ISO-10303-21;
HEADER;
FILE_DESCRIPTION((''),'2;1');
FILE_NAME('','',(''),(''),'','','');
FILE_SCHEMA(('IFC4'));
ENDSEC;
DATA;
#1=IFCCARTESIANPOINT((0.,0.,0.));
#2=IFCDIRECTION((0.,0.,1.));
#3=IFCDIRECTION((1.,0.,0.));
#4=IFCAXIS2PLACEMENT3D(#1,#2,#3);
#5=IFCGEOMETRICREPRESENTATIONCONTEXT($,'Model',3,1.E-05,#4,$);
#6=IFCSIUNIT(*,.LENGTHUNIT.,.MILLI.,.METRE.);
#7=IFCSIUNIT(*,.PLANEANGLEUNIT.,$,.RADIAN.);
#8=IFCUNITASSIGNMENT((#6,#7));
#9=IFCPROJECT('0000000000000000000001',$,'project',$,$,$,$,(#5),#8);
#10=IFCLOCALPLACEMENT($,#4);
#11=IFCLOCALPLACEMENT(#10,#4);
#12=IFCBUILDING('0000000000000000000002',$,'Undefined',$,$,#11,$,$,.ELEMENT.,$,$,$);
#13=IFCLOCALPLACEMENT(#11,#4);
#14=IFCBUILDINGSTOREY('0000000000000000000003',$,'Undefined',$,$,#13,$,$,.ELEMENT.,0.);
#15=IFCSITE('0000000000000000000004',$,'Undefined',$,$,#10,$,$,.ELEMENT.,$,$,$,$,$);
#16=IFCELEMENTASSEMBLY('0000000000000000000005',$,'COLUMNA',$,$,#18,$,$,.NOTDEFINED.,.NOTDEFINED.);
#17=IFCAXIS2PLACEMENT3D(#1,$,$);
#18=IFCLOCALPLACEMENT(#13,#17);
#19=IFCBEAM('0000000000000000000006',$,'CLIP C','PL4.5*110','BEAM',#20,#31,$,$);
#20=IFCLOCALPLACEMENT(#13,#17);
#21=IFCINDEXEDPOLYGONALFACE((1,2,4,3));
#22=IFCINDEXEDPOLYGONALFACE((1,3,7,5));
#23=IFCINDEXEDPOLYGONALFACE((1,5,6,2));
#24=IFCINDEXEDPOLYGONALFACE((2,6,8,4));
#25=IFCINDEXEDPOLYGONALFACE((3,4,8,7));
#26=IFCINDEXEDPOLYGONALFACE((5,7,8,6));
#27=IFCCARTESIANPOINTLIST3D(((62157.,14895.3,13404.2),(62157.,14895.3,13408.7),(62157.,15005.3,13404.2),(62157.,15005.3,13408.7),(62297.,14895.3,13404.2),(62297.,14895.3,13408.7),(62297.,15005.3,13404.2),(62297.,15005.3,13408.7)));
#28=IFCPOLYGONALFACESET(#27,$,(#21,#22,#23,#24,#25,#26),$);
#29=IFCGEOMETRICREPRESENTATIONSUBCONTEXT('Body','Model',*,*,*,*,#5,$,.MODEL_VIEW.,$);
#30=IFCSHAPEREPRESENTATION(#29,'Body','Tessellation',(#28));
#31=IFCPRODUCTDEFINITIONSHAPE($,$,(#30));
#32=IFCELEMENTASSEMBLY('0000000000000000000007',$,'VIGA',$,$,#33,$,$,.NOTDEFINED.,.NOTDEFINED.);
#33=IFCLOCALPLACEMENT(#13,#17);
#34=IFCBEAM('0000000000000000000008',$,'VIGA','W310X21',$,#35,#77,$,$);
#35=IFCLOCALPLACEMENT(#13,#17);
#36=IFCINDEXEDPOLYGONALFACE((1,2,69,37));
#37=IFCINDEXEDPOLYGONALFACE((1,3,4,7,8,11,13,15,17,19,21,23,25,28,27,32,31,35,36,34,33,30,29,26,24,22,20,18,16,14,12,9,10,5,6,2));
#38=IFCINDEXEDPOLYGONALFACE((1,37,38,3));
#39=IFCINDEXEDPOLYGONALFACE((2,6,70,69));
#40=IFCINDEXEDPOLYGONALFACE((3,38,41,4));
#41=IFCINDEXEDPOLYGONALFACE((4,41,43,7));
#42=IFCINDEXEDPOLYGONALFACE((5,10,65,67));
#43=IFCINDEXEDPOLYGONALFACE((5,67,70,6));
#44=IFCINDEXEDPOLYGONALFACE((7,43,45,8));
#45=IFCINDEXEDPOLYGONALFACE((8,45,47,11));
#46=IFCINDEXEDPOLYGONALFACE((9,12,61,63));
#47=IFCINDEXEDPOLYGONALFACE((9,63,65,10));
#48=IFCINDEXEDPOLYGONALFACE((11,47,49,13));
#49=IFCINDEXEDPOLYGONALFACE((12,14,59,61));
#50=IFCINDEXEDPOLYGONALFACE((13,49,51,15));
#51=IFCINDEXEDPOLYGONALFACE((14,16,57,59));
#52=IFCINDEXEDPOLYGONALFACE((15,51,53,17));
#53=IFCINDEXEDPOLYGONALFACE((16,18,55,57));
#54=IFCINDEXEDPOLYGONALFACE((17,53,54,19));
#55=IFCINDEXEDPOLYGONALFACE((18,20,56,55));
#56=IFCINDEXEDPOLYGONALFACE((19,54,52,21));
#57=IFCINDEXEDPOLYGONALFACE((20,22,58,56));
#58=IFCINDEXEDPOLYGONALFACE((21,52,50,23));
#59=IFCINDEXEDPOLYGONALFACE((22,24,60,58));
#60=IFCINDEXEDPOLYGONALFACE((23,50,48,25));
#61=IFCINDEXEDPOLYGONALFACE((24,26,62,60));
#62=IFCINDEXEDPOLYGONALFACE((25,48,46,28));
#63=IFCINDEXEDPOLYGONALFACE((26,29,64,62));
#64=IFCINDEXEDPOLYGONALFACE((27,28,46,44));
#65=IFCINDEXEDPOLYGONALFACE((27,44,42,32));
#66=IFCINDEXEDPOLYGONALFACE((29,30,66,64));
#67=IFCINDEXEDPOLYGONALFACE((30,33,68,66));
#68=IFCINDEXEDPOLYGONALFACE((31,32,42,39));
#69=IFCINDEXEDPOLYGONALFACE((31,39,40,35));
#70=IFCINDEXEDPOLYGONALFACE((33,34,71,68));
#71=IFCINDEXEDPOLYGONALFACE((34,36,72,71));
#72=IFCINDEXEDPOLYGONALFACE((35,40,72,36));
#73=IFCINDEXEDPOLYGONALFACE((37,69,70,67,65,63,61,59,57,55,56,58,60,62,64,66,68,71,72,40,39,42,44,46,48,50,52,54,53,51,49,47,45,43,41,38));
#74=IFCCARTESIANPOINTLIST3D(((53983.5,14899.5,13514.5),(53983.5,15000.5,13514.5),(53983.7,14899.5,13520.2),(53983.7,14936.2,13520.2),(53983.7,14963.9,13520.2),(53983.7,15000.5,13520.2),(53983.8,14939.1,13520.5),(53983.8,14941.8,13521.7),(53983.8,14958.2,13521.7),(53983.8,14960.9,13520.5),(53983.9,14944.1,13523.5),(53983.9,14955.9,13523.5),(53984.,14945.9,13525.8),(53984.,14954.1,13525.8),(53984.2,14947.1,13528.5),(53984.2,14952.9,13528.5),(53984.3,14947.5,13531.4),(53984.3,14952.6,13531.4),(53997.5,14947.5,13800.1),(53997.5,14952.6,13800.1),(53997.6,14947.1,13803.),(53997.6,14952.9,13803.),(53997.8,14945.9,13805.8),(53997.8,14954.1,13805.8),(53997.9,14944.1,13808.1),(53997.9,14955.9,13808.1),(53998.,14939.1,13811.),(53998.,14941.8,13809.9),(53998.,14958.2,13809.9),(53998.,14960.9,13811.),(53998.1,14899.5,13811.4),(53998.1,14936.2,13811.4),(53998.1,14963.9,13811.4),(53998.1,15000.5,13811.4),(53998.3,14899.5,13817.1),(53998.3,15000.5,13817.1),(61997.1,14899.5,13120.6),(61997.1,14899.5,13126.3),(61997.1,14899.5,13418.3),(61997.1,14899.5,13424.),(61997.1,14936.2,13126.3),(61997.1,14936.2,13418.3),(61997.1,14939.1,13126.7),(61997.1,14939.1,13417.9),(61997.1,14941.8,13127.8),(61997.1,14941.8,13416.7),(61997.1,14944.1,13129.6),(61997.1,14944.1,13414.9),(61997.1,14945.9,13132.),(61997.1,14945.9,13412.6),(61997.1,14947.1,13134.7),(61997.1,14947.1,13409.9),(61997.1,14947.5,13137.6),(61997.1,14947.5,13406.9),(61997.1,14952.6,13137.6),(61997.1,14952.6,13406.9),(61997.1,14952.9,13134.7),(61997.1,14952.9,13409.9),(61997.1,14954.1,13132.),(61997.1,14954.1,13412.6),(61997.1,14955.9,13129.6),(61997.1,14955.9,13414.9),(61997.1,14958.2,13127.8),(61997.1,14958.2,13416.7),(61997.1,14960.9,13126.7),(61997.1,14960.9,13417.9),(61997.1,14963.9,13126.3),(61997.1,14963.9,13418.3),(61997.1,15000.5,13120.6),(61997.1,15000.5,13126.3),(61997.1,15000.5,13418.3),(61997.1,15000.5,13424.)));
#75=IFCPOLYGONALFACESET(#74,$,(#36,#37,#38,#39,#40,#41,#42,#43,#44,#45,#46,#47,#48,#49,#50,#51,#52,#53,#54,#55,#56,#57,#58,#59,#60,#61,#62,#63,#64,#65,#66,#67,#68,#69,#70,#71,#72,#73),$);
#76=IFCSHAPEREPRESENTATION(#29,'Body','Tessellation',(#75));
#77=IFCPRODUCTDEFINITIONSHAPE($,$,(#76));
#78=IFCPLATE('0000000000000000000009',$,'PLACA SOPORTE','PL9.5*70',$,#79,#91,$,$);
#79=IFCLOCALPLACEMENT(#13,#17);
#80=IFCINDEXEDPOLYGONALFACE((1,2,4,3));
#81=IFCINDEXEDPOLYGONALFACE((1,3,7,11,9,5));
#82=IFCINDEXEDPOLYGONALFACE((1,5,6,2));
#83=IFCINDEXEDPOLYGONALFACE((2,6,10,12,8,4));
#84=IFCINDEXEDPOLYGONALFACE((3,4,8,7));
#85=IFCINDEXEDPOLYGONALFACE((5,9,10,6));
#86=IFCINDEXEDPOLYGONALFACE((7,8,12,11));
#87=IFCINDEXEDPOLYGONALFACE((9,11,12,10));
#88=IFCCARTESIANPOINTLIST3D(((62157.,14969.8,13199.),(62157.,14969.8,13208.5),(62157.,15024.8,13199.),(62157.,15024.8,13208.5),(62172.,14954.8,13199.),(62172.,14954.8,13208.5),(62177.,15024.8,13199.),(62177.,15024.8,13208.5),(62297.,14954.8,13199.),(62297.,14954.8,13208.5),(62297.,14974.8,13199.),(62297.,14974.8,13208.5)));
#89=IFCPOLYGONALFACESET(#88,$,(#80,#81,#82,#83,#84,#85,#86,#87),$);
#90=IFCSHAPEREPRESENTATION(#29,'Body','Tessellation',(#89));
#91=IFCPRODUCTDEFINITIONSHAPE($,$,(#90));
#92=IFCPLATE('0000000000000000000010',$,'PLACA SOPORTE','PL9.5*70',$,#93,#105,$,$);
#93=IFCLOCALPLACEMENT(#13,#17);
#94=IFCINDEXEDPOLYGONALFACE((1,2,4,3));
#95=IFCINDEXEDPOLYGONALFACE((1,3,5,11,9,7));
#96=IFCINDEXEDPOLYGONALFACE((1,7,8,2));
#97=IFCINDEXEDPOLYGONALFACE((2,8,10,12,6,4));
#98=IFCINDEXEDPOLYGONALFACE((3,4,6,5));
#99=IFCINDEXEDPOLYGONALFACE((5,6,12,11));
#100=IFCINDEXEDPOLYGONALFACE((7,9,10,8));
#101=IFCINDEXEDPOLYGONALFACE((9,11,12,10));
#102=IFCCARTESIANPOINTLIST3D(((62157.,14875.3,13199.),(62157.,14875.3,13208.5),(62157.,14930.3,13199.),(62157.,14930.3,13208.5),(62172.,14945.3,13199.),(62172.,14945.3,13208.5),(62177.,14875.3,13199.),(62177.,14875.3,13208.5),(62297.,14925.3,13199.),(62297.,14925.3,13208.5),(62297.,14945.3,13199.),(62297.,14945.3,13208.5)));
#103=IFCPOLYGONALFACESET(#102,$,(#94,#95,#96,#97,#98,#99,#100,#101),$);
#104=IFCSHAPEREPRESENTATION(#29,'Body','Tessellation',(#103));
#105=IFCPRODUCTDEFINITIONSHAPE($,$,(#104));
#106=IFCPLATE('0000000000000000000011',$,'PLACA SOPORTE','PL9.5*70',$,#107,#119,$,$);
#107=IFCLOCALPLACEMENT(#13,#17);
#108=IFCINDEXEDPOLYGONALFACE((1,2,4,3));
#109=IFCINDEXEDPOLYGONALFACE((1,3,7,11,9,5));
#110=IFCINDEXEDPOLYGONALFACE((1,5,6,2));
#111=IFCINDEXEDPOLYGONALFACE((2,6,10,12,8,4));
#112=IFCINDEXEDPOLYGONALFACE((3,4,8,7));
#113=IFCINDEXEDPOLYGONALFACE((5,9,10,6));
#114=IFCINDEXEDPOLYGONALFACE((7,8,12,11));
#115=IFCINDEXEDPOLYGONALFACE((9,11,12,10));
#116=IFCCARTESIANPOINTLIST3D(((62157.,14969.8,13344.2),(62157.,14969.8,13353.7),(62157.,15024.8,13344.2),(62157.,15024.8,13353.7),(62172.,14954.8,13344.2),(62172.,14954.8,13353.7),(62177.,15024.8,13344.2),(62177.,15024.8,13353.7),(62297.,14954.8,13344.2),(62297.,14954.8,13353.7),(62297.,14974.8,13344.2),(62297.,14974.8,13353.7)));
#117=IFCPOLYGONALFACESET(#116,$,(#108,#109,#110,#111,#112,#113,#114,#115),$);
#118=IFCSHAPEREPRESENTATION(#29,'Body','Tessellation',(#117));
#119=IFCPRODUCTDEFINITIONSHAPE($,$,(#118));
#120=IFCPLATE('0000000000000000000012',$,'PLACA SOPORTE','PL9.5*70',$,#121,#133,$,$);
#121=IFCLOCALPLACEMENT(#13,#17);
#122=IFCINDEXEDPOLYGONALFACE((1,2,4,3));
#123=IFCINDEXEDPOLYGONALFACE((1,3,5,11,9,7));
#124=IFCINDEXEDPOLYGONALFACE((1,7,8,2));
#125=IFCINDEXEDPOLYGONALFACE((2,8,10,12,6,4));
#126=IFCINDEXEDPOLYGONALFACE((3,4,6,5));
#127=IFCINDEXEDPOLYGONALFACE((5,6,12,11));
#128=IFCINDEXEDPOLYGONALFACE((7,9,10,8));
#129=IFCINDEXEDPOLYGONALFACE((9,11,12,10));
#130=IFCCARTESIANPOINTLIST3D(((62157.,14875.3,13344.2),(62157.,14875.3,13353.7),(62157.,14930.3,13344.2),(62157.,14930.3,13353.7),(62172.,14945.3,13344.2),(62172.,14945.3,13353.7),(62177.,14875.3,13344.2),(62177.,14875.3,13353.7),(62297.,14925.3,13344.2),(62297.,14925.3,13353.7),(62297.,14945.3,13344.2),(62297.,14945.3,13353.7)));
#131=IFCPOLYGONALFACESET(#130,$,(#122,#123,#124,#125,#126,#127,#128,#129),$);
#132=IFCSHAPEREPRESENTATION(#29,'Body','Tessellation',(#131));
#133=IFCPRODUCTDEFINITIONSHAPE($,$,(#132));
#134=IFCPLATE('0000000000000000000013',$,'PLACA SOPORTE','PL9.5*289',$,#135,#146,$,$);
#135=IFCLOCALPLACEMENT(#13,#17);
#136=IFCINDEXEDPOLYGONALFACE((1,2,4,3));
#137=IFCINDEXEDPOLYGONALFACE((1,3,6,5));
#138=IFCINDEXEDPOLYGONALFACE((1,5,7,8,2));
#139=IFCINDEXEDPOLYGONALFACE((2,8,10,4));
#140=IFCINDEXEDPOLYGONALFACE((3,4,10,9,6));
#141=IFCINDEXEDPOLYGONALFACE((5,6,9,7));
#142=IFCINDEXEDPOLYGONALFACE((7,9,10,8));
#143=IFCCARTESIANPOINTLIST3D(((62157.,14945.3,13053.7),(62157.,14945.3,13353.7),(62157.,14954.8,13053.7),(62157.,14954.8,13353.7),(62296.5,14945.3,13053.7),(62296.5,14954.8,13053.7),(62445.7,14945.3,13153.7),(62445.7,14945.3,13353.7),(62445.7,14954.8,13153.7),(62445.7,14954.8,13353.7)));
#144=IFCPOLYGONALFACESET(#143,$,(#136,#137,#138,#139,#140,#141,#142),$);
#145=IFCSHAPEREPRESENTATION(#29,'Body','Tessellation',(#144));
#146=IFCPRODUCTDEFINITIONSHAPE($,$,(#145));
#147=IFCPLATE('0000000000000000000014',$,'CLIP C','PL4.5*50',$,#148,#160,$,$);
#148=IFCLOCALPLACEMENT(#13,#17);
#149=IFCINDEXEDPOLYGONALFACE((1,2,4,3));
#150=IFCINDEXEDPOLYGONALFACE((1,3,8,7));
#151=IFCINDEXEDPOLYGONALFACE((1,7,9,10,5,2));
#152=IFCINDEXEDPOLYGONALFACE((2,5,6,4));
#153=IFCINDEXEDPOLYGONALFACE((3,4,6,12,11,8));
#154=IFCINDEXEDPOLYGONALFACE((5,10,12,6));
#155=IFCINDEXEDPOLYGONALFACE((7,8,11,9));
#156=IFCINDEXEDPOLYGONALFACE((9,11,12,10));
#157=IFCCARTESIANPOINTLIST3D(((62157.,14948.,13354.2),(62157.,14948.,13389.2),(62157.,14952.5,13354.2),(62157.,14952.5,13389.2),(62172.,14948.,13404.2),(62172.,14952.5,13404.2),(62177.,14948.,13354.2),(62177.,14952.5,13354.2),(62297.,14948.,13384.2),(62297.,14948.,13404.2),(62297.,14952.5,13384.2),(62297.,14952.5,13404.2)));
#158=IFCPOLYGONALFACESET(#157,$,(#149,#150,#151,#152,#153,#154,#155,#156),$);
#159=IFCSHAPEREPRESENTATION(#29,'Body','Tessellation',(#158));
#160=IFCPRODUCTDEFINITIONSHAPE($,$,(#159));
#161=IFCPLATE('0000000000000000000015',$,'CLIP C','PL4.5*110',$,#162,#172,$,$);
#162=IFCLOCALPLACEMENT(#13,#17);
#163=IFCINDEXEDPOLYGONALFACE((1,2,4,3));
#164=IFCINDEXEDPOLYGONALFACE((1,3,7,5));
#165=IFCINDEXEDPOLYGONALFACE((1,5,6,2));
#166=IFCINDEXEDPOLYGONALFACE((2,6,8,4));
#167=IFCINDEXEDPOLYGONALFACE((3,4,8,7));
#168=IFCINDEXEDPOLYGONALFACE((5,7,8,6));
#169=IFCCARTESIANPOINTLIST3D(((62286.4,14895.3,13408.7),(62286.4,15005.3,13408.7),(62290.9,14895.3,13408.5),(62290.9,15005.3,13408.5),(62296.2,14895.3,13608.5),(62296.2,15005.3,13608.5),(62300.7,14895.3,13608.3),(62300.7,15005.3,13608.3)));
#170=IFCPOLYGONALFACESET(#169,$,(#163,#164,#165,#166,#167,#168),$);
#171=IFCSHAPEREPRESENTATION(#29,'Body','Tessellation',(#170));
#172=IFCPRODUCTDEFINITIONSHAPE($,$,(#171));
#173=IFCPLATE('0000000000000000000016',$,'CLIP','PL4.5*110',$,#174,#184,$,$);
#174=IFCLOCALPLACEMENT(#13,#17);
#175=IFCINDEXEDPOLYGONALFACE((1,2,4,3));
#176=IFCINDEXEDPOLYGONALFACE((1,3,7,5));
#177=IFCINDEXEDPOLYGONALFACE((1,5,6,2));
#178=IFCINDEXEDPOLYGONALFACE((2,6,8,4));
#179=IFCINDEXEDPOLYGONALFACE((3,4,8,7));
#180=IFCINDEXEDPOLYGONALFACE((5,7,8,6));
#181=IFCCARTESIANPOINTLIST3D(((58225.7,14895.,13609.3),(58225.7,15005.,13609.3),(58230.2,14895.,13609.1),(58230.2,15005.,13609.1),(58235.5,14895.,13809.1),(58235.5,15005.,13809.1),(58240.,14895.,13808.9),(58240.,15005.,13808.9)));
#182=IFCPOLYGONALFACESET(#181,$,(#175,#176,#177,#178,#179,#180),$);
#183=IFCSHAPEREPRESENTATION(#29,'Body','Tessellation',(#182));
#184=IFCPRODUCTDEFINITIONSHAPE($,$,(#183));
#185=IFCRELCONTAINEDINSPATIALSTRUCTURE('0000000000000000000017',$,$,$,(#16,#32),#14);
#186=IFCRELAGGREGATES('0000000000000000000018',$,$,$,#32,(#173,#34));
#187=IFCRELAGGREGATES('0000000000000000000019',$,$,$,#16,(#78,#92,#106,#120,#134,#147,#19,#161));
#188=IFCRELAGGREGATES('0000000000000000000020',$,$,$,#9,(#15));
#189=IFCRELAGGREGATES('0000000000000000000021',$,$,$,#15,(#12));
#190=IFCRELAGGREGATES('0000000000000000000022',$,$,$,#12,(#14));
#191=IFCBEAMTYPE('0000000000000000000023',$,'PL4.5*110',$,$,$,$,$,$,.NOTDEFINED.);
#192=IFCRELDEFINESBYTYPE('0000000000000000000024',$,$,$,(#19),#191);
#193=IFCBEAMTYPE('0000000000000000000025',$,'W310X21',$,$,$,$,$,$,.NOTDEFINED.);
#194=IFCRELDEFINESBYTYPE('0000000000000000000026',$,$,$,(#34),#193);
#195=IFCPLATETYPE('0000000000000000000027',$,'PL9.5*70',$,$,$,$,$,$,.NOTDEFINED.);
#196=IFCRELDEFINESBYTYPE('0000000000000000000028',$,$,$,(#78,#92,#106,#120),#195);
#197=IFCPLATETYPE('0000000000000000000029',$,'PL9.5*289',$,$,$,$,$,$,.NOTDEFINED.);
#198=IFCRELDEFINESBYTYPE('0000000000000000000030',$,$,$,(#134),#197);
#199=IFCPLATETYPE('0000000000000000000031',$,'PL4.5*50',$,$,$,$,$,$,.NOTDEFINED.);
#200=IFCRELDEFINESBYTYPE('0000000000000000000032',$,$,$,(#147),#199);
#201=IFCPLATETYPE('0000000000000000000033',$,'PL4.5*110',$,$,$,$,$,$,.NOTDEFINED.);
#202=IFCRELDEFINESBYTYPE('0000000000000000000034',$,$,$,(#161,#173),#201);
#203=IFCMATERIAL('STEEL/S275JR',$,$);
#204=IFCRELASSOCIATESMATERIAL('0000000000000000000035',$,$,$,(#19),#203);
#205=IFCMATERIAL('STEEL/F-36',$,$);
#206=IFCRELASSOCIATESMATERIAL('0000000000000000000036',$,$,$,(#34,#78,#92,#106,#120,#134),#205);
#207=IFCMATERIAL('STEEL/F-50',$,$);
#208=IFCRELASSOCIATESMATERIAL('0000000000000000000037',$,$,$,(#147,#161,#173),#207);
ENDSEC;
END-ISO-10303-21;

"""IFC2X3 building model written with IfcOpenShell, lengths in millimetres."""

from ifc_helpers import new_model, si_unit, frame, origin_with_axes, origin_2d_with_axis, place, context, subcontext, project, spatial, polyline, rectangle, i_section, outline, extrude, clip, halfspace, material, type_object, element, aggregate, save


model = new_model("IFC2X3")

# Units and contexts
model_context = context("Model", 3, precision=1e-05, world=origin_with_axes())
body_context = subcontext(model_context, "Body", "Model", "MODEL_VIEW")
ifc_project = project(units=[si_unit("LENGTHUNIT", "METRE", prefix="MILLI"), si_unit("PLANEANGLEUNIT", "RADIAN")], contexts=[model_context])

# Site, building, storey
site_placement = place(None, origin_with_axes())
site = spatial("IfcSite", under=ifc_project, at=site_placement, Name="Undefined", CompositionType="ELEMENT")
building_placement = place(site_placement, origin_with_axes())
building = spatial("IfcBuilding", under=site, at=building_placement, Name="Undefined", CompositionType="ELEMENT")
storey_placement = place(building_placement, origin_with_axes())
storey = spatial("IfcBuildingStorey", under=building, at=storey_placement, Name="Undefined", CompositionType="ELEMENT", Elevation=0.0)

# Element assemblies, beams
assembly_1_placement = place(storey_placement, origin_with_axes())
assembly_1 = element("IfcElementAssembly", 1, at=assembly_1_placement, inside=storey, Name="COLUMNA", AssemblyPlace="NOTDEFINED", PredefinedType="NOTDEFINED")
ifc_material_1 = material(Name="STEEL/S275JR")
beam_type_1 = type_object("IfcBeamType", Name="PL4.5*110", PredefinedType="NOTDEFINED")
beam_1_placement = place(assembly_1_placement, frame((62297.0, 14950.3, 13406.5), z_axis=(0.0, -1.0, 0.0), x_axis=(-1.0, 0.0, 0.0)))
beam_1 = element("IfcBeam", 2, at=beam_1_placement, type_object=beam_type_1, material=ifc_material_1, Name="CLIP C", Description="PL4.5*110", ObjectType="BEAM", context=body_context, shape_type="SweptSolid", body=[
    extrude(rectangle(XDim=4.5, YDim=110.0, at=origin_2d_with_axis()), frame((140.0, 0.0, 0.0), z_axis=(-1.0, 0.0, 0.0), x_axis=(0.0, -1.0, 0.0)), (0.0, 0.0, 1.0), 140.0),
])
assembly_2_placement = place(storey_placement, origin_with_axes())
assembly_2 = element("IfcElementAssembly", 3, at=assembly_2_placement, inside=storey, Name="VIGA", AssemblyPlace="NOTDEFINED", PredefinedType="NOTDEFINED")
ifc_material_2 = material(Name="STEEL/F-36")
beam_type_2 = type_object("IfcBeamType", Name="W310X21", PredefinedType="NOTDEFINED")
beam_2_placement = place(assembly_2_placement, frame((62081.1, 14950.0, 13268.2), z_axis=(0.04909, 0.0, 0.998794), x_axis=(-0.998794, 0.0, 0.04909)))
beam_2 = element("IfcBeam", 4, at=beam_2_placement, type_object=beam_type_2, material=ifc_material_2, Name="VIGA", Description="W310X21", context=body_context, shape_type="Clipping", body=[
    clip(extrude(i_section(OverallWidth=101.0, OverallDepth=303.0, WebThickness=5.1, FlangeThickness=5.7, FilletRadius=11.3, at=origin_2d_with_axis()), frame((8099.9, 0.0, 0.0), z_axis=(-1.0, 0.0, 0.0), x_axis=(0.0, -1.0, 0.0)), (0.0, 0.0, 1.0), 8099.9), halfspace(frame((91.5, 0.0, 151.5), z_axis=(0.998794, 0.0, -0.049091), x_axis=(0.0, 1.0, 0.0)), True)),
])

# Plates
plate_type_1 = type_object("IfcPlateType", Name="PL9.5*70", PredefinedType="NOTDEFINED")
plate_1_placement = place(assembly_1_placement, frame((62157.0, 14954.8, 13203.7), z_axis=(0.0, 0.0, -1.0), x_axis=(0.00004, 1.0, 0.0)))
plate_1 = element("IfcPlate", 5, at=plate_1_placement, type_object=plate_type_1, material=ifc_material_2, Name="PLACA SOPORTE", Description="PL9.5*70", context=body_context, shape_type="SweptSolid", body=[
    extrude(outline(polyline([(0.0, 15.0), (15.0, 0.0), (70.0, 0.0), (70.0, 20.0), (20.0, 140.0), (0.0, 140.0), (0.0, 15.0)])), frame((0.0, 0.0, -4.8), z_axis=(0.0, 0.0, 1.0), x_axis=(1.0, 0.0, 0.0)), (0.0, 0.0, 1.0), 9.5),
])
plate_2_placement = place(assembly_1_placement, frame((62157.0, 14945.3, 13203.7), z_axis=(0.0, 0.0, 1.0), x_axis=(0.00004, -1.0, 0.0)))
plate_2 = element("IfcPlate", 6, at=plate_2_placement, type_object=plate_type_1, material=ifc_material_2, Name="PLACA SOPORTE", Description="PL9.5*70", context=body_context, shape_type="SweptSolid", body=[
    extrude(outline(polyline([(0.0, 15.0), (15.0, 0.0), (70.0, 0.0), (70.0, 20.0), (20.0, 140.0), (0.0, 140.0), (0.0, 15.0)])), frame((0.0, 0.0, -4.8), z_axis=(0.0, 0.0, 1.0), x_axis=(1.0, 0.0, 0.0)), (0.0, 0.0, 1.0), 9.5),
])
plate_3_placement = place(assembly_1_placement, frame((62157.0, 14954.8, 13349.0), z_axis=(0.0, 0.0, -1.0), x_axis=(0.00004, 1.0, 0.0)))
plate_3 = element("IfcPlate", 7, at=plate_3_placement, type_object=plate_type_1, material=ifc_material_2, Name="PLACA SOPORTE", Description="PL9.5*70", context=body_context, shape_type="SweptSolid", body=[
    extrude(outline(polyline([(0.0, 15.0), (15.0, 0.0), (70.0, 0.0), (70.0, 20.0), (20.0, 140.0), (0.0, 140.0), (0.0, 15.0)])), frame((0.0, 0.0, -4.8), z_axis=(0.0, 0.0, 1.0), x_axis=(1.0, 0.0, 0.0)), (0.0, 0.0, 1.0), 9.5),
])
plate_4_placement = place(assembly_1_placement, frame((62157.0, 14945.3, 13349.0), z_axis=(0.0, 0.0, 1.0), x_axis=(0.00004, -1.0, 0.0)))
plate_4 = element("IfcPlate", 8, at=plate_4_placement, type_object=plate_type_1, material=ifc_material_2, Name="PLACA SOPORTE", Description="PL9.5*70", context=body_context, shape_type="SweptSolid", body=[
    extrude(outline(polyline([(0.0, 15.0), (15.0, 0.0), (70.0, 0.0), (70.0, 20.0), (20.0, 140.0), (0.0, 140.0), (0.0, 15.0)])), frame((0.0, 0.0, -4.8), z_axis=(0.0, 0.0, 1.0), x_axis=(1.0, 0.0, 0.0)), (0.0, 0.0, 1.0), 9.5),
])
plate_type_2 = type_object("IfcPlateType", Name="PL9.5*289", PredefinedType="NOTDEFINED")
plate_5_placement = place(assembly_1_placement, frame((62157.0, 14950.0, 13353.7), z_axis=(0.0, 1.0, 0.0), x_axis=(1.0, 0.0, 0.0)))
plate_5 = element("IfcPlate", 9, at=plate_5_placement, type_object=plate_type_2, material=ifc_material_2, Name="PLACA SOPORTE", Description="PL9.5*289", context=body_context, shape_type="SweptSolid", body=[
    extrude(outline(polyline([(0.0, 0.0), (288.8, 0.0), (288.8, 200.0), (139.5, 300.0), (0.0, 300.0), (0.0, 0.0)])), frame((0.0, 0.0, -4.8), z_axis=(0.0, 0.0, 1.0), x_axis=(1.0, 0.0, 0.0)), (0.0, 0.0, 1.0), 9.5),
])
ifc_material_3 = material(Name="STEEL/F-50")
plate_type_3 = type_object("IfcPlateType", Name="PL4.5*50", PredefinedType="NOTDEFINED")
plate_6_placement = place(assembly_1_placement, frame((62157.0, 14950.3, 13404.2), z_axis=(0.0, 1.0, 0.0), x_axis=(1.0, 0.0, 0.0)))
plate_6 = element("IfcPlate", 10, at=plate_6_placement, type_object=plate_type_3, material=ifc_material_3, Name="CLIP C", Description="PL4.5*50", context=body_context, shape_type="SweptSolid", body=[
    extrude(outline(polyline([(0.0, 15.0), (15.0, 0.0), (140.0, 0.0), (140.0, 20.0), (20.0, 50.0), (0.0, 50.0), (0.0, 15.0)])), frame((0.0, 0.0, -2.2), z_axis=(0.0, 0.0, 1.0), x_axis=(1.0, 0.0, 0.0)), (0.0, 0.0, 1.0), 4.5),
])
plate_type_4 = type_object("IfcPlateType", Name="PL4.5*110", PredefinedType="NOTDEFINED")
plate_7_placement = place(assembly_1_placement, frame((62288.6, 15005.3, 13408.6), z_axis=(-0.998794, 0.0, 0.04909), x_axis=(0.0, -1.0, 0.0)))
plate_7 = element("IfcPlate", 11, at=plate_7_placement, type_object=plate_type_4, material=ifc_material_3, Name="CLIP C", Description="PL4.5*110", context=body_context, shape_type="SweptSolid", body=[
    extrude(outline(polyline([(0.0, 0.0), (110.0, 0.0), (110.0, 200.0), (0.0, 200.0), (0.0, 0.0)])), frame((0.0, 0.0, -2.2), z_axis=(0.0, 0.0, 1.0), x_axis=(1.0, 0.0, 0.0)), (0.0, 0.0, 1.0), 4.5),
])
plate_8_placement = place(assembly_2_placement, frame((58227.9, 15005.0, 13609.2), z_axis=(-0.998794, 0.0, 0.04909), x_axis=(0.0, -1.0, 0.0)))
plate_8 = element("IfcPlate", 12, at=plate_8_placement, type_object=plate_type_4, material=ifc_material_3, Name="CLIP", Description="PL4.5*110", context=body_context, shape_type="SweptSolid", body=[
    extrude(outline(polyline([(0.0, 0.0), (110.0, 0.0), (110.0, 200.0), (0.0, 200.0), (0.0, 0.0)])), frame((0.0, 0.0, -2.2), z_axis=(0.0, 0.0, 1.0), x_axis=(1.0, 0.0, 0.0)), (0.0, 0.0, 1.0), 4.5),
])

aggregate(assembly_2, [plate_8, beam_2])

aggregate(assembly_1, [plate_1, plate_2, plate_3, plate_4, plate_5, plate_6, beam_1, plate_7])

save(model, "model.ifc")
